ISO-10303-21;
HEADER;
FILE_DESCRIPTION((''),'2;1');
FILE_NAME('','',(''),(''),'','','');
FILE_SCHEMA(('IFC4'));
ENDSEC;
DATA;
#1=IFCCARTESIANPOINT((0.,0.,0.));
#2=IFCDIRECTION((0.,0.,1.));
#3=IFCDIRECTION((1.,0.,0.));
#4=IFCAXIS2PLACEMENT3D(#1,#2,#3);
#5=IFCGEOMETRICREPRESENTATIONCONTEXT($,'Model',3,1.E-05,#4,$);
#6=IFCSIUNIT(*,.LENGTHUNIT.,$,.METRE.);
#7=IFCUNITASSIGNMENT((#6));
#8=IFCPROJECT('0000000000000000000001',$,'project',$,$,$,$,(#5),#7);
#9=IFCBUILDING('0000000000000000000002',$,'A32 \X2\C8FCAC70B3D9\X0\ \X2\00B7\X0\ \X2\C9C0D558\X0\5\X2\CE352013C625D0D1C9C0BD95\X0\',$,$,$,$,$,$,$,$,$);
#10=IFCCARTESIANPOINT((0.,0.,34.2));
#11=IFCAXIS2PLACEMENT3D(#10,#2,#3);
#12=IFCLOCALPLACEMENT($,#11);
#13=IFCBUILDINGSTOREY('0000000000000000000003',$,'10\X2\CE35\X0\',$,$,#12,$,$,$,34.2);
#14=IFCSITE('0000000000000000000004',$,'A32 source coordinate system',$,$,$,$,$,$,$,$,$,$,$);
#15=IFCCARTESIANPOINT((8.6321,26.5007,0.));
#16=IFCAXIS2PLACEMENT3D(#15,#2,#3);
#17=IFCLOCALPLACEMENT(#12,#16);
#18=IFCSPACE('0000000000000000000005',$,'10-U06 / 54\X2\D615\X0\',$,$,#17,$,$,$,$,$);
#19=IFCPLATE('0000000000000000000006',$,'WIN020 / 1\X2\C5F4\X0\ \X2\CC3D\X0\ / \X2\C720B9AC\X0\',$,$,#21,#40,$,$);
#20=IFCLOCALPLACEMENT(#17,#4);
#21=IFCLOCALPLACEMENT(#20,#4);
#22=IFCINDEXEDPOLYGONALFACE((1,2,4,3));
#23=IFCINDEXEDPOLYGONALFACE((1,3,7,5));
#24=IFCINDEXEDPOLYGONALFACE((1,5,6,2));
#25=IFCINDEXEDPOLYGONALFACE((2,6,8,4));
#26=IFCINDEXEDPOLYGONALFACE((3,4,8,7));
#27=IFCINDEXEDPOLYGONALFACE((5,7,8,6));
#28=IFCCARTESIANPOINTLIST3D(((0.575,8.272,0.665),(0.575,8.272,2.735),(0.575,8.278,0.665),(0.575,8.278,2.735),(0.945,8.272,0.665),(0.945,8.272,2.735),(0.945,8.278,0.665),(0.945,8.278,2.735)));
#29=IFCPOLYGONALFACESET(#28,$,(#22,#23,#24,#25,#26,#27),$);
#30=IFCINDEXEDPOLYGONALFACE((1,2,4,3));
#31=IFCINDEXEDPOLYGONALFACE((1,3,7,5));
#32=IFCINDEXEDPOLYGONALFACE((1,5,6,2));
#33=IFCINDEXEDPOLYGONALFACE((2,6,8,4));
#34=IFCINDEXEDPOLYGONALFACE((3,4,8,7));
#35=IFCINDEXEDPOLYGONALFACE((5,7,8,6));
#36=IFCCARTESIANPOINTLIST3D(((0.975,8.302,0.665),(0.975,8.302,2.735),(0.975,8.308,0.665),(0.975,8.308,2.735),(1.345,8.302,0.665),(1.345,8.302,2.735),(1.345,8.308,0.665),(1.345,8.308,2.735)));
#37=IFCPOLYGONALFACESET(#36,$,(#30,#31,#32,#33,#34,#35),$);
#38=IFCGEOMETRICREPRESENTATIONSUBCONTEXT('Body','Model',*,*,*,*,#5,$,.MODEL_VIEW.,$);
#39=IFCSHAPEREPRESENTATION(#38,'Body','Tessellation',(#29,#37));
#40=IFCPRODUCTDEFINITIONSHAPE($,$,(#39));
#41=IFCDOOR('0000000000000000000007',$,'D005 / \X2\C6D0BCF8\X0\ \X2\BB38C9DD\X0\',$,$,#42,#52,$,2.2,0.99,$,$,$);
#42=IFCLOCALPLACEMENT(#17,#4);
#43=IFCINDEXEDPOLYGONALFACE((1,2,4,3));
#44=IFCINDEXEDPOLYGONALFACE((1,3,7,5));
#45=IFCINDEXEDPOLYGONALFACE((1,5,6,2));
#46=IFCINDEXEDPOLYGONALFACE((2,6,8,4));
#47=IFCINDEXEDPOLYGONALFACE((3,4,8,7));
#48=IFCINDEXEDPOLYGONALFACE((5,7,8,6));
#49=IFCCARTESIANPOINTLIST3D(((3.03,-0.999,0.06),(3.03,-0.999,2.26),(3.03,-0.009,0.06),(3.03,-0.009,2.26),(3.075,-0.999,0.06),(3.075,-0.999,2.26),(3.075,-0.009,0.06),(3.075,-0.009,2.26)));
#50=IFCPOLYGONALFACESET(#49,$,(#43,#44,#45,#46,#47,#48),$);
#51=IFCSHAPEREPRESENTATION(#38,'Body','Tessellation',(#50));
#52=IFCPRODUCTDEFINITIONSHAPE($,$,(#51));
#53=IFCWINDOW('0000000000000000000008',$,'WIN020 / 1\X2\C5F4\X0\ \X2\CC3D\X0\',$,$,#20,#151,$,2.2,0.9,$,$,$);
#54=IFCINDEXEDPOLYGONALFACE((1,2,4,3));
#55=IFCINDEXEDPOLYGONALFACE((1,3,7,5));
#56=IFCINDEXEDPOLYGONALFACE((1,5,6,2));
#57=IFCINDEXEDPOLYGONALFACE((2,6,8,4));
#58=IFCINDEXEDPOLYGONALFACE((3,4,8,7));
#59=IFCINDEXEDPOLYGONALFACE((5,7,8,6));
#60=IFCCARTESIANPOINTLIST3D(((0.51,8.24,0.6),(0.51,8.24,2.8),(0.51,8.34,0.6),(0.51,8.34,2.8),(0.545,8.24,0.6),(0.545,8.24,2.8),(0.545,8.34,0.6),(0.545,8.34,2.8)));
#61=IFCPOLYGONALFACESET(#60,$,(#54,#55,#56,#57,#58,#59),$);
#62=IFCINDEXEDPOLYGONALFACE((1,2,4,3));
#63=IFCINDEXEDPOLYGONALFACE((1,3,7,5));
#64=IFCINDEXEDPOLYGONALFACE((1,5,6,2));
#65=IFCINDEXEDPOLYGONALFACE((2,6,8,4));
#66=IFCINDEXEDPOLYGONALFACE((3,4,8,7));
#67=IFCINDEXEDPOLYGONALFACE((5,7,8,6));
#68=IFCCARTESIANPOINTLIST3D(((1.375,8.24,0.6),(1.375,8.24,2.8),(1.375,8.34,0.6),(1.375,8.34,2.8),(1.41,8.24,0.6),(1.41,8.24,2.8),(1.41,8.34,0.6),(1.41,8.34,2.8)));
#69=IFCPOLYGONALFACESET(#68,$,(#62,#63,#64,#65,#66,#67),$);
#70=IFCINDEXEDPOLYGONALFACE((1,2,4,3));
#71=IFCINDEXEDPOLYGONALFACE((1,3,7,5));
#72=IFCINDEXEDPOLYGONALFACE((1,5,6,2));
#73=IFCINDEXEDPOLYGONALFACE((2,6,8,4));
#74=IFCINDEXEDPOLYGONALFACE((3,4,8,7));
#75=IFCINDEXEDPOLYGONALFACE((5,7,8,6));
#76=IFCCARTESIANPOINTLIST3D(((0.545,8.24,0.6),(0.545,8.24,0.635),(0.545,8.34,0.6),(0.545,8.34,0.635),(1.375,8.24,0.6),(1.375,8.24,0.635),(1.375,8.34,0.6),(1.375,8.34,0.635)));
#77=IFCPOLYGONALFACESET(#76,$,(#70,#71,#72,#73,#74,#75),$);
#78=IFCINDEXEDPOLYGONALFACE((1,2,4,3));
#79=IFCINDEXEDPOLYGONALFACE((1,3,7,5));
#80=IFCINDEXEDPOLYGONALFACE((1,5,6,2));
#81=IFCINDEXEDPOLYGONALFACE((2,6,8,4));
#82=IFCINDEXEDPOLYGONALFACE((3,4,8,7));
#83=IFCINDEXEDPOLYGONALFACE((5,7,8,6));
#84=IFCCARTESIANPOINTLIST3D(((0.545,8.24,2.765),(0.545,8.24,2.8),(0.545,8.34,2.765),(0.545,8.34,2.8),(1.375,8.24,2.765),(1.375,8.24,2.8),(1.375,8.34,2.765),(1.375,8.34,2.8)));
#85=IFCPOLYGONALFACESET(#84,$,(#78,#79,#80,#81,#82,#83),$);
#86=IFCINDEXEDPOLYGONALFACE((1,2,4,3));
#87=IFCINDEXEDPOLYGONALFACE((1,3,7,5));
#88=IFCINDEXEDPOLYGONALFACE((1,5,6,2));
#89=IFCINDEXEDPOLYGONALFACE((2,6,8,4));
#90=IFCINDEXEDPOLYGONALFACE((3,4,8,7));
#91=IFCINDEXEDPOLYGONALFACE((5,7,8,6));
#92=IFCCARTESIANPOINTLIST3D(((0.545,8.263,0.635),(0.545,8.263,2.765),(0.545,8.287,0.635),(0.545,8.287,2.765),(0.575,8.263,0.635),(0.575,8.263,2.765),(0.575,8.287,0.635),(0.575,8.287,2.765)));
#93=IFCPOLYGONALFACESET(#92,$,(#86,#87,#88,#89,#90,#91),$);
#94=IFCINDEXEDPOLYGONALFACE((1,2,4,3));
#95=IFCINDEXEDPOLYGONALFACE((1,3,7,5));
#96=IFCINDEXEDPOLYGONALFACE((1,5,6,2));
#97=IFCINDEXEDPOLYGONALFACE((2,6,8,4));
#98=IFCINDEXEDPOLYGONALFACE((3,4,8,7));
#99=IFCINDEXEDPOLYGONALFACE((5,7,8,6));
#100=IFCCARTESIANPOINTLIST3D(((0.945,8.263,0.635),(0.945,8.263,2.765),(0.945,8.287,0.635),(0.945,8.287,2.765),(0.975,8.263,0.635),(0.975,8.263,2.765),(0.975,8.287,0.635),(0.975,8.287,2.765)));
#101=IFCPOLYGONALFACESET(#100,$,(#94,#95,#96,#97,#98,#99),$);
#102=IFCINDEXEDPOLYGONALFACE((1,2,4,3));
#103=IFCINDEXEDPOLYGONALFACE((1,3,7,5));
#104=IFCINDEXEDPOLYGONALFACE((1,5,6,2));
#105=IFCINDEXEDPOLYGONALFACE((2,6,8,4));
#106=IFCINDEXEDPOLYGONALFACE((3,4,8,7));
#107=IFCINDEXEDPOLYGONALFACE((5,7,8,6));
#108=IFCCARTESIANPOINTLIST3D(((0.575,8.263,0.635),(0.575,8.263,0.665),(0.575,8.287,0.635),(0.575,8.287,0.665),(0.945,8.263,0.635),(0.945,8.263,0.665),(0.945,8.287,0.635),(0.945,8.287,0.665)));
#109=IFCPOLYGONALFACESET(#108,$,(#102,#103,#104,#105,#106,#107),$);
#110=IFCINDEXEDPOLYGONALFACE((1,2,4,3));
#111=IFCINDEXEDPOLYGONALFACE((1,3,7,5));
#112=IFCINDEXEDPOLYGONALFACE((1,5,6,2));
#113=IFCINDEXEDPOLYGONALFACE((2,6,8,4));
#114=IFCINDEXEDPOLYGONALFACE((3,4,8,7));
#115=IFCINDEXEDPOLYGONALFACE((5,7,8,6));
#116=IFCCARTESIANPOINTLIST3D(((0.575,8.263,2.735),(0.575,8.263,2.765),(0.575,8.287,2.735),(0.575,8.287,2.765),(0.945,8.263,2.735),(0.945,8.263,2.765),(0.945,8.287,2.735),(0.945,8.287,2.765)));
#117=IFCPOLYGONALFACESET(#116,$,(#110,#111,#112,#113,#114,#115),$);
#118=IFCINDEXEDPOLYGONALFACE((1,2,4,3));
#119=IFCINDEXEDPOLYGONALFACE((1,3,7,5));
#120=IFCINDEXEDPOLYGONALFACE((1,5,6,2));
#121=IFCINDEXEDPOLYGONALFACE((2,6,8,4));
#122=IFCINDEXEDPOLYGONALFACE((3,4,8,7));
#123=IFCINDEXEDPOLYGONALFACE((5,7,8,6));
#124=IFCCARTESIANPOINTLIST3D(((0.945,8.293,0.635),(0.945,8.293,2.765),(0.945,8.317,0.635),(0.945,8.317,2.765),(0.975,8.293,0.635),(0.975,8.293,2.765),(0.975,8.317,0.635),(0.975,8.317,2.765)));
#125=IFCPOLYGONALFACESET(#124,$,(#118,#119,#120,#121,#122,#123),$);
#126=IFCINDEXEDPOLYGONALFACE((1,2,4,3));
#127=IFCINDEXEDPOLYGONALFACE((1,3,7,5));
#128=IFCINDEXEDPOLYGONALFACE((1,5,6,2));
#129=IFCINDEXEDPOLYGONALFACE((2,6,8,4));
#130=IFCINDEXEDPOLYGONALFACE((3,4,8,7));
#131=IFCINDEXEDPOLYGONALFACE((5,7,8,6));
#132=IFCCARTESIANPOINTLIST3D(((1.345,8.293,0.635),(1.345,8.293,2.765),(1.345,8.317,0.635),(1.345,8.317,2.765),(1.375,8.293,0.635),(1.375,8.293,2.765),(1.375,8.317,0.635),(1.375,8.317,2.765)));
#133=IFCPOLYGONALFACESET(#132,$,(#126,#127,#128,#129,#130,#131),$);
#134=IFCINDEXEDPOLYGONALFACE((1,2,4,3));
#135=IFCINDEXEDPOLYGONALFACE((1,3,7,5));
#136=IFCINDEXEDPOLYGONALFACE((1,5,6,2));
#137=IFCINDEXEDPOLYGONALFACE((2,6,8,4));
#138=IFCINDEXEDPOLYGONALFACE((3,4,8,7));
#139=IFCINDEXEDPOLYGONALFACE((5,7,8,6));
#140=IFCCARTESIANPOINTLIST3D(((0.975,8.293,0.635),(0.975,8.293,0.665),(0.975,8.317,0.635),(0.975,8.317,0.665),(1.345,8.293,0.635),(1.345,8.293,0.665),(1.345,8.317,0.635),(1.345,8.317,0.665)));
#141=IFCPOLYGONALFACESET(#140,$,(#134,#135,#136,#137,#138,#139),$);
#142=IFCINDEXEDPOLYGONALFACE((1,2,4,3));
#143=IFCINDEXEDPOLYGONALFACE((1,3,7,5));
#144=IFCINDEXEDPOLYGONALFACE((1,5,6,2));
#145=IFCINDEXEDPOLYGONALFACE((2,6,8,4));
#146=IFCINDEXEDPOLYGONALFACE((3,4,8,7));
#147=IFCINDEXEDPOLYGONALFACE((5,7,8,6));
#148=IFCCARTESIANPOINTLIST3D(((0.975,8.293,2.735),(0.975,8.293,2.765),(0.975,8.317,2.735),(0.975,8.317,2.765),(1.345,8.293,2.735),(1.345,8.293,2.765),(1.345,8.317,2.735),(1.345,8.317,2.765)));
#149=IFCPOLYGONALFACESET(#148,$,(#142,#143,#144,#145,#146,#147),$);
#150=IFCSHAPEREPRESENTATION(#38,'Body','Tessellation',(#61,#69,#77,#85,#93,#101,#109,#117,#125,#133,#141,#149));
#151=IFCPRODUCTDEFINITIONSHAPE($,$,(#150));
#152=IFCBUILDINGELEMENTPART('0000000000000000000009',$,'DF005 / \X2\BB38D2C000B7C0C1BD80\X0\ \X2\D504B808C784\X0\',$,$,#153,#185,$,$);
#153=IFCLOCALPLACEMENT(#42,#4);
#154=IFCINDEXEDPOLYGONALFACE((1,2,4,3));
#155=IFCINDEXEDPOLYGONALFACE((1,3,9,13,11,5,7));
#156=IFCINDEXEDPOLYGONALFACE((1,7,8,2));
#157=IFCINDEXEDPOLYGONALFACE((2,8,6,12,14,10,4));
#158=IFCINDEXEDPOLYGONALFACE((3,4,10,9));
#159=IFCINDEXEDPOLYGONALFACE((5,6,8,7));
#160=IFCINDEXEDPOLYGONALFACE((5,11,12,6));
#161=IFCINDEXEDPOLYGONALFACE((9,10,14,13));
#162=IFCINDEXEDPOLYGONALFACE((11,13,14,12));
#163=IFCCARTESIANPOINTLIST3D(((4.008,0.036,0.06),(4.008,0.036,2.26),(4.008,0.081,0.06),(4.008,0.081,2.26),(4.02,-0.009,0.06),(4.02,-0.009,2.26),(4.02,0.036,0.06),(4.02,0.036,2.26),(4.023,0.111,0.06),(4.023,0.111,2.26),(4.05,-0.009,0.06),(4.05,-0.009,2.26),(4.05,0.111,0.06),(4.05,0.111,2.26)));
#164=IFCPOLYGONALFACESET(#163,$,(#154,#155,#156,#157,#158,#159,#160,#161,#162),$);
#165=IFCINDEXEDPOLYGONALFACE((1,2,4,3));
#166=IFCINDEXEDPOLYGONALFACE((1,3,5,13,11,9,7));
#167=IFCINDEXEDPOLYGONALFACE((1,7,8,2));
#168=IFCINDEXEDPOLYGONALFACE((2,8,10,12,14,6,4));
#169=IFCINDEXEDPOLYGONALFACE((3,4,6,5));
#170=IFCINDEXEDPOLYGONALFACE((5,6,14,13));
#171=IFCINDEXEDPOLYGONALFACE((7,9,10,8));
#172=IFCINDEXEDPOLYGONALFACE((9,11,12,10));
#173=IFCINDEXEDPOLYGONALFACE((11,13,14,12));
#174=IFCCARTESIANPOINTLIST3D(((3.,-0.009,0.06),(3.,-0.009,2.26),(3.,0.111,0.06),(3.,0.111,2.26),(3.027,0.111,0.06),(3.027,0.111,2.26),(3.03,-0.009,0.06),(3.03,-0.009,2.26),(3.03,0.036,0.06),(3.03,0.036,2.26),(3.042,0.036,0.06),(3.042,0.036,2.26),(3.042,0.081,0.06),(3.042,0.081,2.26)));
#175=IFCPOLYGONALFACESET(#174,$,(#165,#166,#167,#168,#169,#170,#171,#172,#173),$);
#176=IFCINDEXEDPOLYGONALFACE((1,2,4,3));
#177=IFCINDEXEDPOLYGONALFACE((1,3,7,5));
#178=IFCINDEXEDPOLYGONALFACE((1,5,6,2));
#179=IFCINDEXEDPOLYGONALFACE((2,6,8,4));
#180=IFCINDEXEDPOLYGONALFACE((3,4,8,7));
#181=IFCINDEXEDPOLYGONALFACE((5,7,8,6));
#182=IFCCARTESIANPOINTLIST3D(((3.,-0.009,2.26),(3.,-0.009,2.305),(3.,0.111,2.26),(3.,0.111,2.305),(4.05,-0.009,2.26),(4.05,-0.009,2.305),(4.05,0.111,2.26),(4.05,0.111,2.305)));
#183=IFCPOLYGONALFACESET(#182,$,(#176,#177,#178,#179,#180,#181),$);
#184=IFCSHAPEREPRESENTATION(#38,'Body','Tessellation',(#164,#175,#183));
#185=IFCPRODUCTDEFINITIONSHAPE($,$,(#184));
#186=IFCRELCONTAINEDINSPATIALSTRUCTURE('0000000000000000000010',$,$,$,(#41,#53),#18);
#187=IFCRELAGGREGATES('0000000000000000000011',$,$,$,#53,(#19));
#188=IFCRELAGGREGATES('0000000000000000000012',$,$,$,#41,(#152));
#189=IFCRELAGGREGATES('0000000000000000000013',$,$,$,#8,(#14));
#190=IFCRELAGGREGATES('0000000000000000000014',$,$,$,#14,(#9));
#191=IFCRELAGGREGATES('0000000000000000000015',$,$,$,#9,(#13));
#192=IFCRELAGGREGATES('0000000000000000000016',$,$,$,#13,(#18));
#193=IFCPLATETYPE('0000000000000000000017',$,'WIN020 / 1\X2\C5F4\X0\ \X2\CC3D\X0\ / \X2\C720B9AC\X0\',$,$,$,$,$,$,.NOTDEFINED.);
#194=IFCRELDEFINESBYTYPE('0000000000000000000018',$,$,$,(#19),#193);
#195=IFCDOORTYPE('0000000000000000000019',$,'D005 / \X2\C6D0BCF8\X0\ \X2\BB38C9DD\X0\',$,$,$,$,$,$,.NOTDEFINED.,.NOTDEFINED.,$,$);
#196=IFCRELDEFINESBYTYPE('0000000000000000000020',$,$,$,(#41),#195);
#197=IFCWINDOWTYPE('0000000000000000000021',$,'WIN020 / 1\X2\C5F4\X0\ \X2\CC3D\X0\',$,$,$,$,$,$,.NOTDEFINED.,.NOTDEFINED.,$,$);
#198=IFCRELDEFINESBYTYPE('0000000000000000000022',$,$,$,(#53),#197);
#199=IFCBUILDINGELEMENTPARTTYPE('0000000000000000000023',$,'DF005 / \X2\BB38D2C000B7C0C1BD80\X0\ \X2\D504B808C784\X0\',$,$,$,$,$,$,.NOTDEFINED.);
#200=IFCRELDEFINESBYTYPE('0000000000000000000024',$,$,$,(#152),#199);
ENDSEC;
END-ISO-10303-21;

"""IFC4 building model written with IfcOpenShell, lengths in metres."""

from ifc_helpers import new_model, si_unit, frame, origin, origin_with_axes, place, context, subcontext, project, spatial, polyline, outline, extrude, source, transform, mapped, type_object, type_shapes, element, aggregate, save


model = new_model("IFC4")

# Units and contexts
model_context = context("Model", 3, precision=1e-05, world=origin_with_axes())
body_context = subcontext(model_context, "Body", "Model", "MODEL_VIEW")
ifc_project = project(units=[si_unit("LENGTHUNIT", "METRE")], contexts=[model_context])

# Plate
storey_placement = place(None, frame((0.0, 0.0, 34.2), z_axis=(0.0, 0.0, 1.0), x_axis=(1.0, 0.0, 0.0)))
space_1_placement = place(storey_placement, frame((8.6321, 26.5007, 0.0), z_axis=(0.0, 0.0, 1.0), x_axis=(1.0, 0.0, 0.0)))
plate_type_1 = type_object("IfcPlateType", Name="WIN020 / 1열 창 / 유리", PredefinedType="NOTDEFINED")
shared_shape_1 = source(origin(), body_context, "Body", "SweptSolid", [
    extrude(outline(polyline([(0.575, 8.272), (0.575, 8.278), (0.945, 8.278), (0.945, 8.272), (0.575, 8.272)])), frame((0.0, 0.0, 0.665)), (0.0, 0.0, 1.0), 2.07),
    extrude(outline(polyline([(0.975, 8.302), (0.975, 8.308), (1.345, 8.308), (1.345, 8.302), (0.975, 8.302)])), frame((0.0, 0.0, 0.665)), (0.0, 0.0, 1.0), 2.07),
])
type_shapes(plate_type_1, [shared_shape_1])
window_1_placement = place(space_1_placement, origin_with_axes())
plate_1_placement = place(window_1_placement, origin_with_axes())
plate_1 = element("IfcPlate", 1, at=plate_1_placement, type_object=plate_type_1, Name="WIN020 / 1열 창 / 유리", context=body_context, shape_type="MappedRepresentation", body=[
    mapped(shared_shape_1, transform((0.0, 0.0, 0.0), scale=1.0)),
])

# Site, building, storey, space
site = spatial("IfcSite", under=ifc_project, Name="A32 source coordinate system")
building = spatial("IfcBuilding", under=site, Name="A32 주거동 · 지하5층–옥탑지붕")
storey = spatial("IfcBuildingStorey", under=building, at=storey_placement, Name="10층", Elevation=34.2)
space_1 = spatial("IfcSpace", under=storey, at=space_1_placement, Name="10-U06 / 54형")

# Door
door_type_1 = type_object("IfcDoorType", Name="D005 / 원본 문짝", OperationType="NOTDEFINED", PredefinedType="NOTDEFINED")
shared_shape_2 = source(origin(), body_context, "Body", "SweptSolid", [
    extrude(outline(polyline([(3.075, -0.999), (3.03, -0.999), (3.03, -0.009), (3.075, -0.009), (3.075, -0.999)])), frame((0.0, 0.0, 0.06)), (0.0, 0.0, 1.0), 2.2),
])
type_shapes(door_type_1, [shared_shape_2])
door_1_placement = place(space_1_placement, origin_with_axes())
door_1 = element("IfcDoor", 2, at=door_1_placement, inside=space_1, type_object=door_type_1, Name="D005 / 원본 문짝", OverallHeight=2.2, OverallWidth=0.99, context=body_context, shape_type="MappedRepresentation", body=[
    mapped(shared_shape_2, transform((0.0, 0.0, 0.0), scale=1.0)),
])

# Window
window_type_1 = type_object("IfcWindowType", Name="WIN020 / 1열 창", PartitioningType="NOTDEFINED", PredefinedType="NOTDEFINED")
shared_shape_3 = source(origin(), body_context, "Body", "SweptSolid", [
    extrude(outline(polyline([(0.51, 8.24), (0.51, 8.34), (0.545, 8.34), (0.545, 8.24), (0.51, 8.24)])), frame((0.0, 0.0, 0.6)), (0.0, 0.0, 1.0), 2.2),
    extrude(outline(polyline([(1.375, 8.24), (1.375, 8.34), (1.41, 8.34), (1.41, 8.24), (1.375, 8.24)])), frame((0.0, 0.0, 0.6)), (0.0, 0.0, 1.0), 2.2),
    extrude(outline(polyline([(0.545, 8.24), (0.545, 8.34), (1.375, 8.34), (1.375, 8.24), (0.545, 8.24)])), frame((0.0, 0.0, 0.6)), (0.0, 0.0, 1.0), 0.035),
    extrude(outline(polyline([(0.545, 8.24), (0.545, 8.34), (1.375, 8.34), (1.375, 8.24), (0.545, 8.24)])), frame((0.0, 0.0, 2.765)), (0.0, 0.0, 1.0), 0.035),
    extrude(outline(polyline([(0.545, 8.263), (0.545, 8.287), (0.575, 8.287), (0.575, 8.263), (0.545, 8.263)])), frame((0.0, 0.0, 0.635)), (0.0, 0.0, 1.0), 2.13),
    extrude(outline(polyline([(0.945, 8.263), (0.945, 8.287), (0.975, 8.287), (0.975, 8.263), (0.945, 8.263)])), frame((0.0, 0.0, 0.635)), (0.0, 0.0, 1.0), 2.13),
    extrude(outline(polyline([(0.575, 8.263), (0.575, 8.287), (0.945, 8.287), (0.945, 8.263), (0.575, 8.263)])), frame((0.0, 0.0, 0.635)), (0.0, 0.0, 1.0), 0.03),
    extrude(outline(polyline([(0.575, 8.263), (0.575, 8.287), (0.945, 8.287), (0.945, 8.263), (0.575, 8.263)])), frame((0.0, 0.0, 2.735)), (0.0, 0.0, 1.0), 0.03),
    extrude(outline(polyline([(0.945, 8.293), (0.945, 8.317), (0.975, 8.317), (0.975, 8.293), (0.945, 8.293)])), frame((0.0, 0.0, 0.635)), (0.0, 0.0, 1.0), 2.13),
    extrude(outline(polyline([(1.345, 8.293), (1.345, 8.317), (1.375, 8.317), (1.375, 8.293), (1.345, 8.293)])), frame((0.0, 0.0, 0.635)), (0.0, 0.0, 1.0), 2.13),
    extrude(outline(polyline([(0.975, 8.293), (0.975, 8.317), (1.345, 8.317), (1.345, 8.293), (0.975, 8.293)])), frame((0.0, 0.0, 0.635)), (0.0, 0.0, 1.0), 0.03),
    extrude(outline(polyline([(0.975, 8.293), (0.975, 8.317), (1.345, 8.317), (1.345, 8.293), (0.975, 8.293)])), frame((0.0, 0.0, 2.735)), (0.0, 0.0, 1.0), 0.03),
])
type_shapes(window_type_1, [shared_shape_3])
window_1 = element("IfcWindow", 3, at=window_1_placement, inside=space_1, type_object=window_type_1, Name="WIN020 / 1열 창", OverallHeight=2.2, OverallWidth=0.9, context=body_context, shape_type="MappedRepresentation", body=[
    mapped(shared_shape_3, transform((0.0, 0.0, 0.0), scale=1.0)),
])
aggregate(window_1, [plate_1])

# Building element part
building_element_part_type_1 = type_object("IfcBuildingElementPartType", Name="DF005 / 문틀·상부 프레임", PredefinedType="NOTDEFINED")
shared_shape_4 = source(origin(), body_context, "Body", "SweptSolid", [
    extrude(outline(polyline([(4.02, -0.009), (4.02, 0.036), (4.008, 0.036), (4.008, 0.081), (4.023, 0.111), (4.05, 0.111), (4.05, -0.009), (4.02, -0.009)])), frame((0.0, 0.0, 0.06)), (0.0, 0.0, 1.0), 2.2),
    extrude(outline(polyline([(3.0, 0.111), (3.027, 0.111), (3.042, 0.081), (3.042, 0.036), (3.03, 0.036), (3.03, -0.009), (3.0, -0.009), (3.0, 0.111)])), frame((0.0, 0.0, 0.06)), (0.0, 0.0, 1.0), 2.2),
    extrude(outline(polyline([(3.0, -0.009), (3.0, 0.111), (4.05, 0.111), (4.05, -0.009), (3.0, -0.009)])), frame((0.0, 0.0, 2.26)), (0.0, 0.0, 1.0), 0.045),
])
type_shapes(building_element_part_type_1, [shared_shape_4])
building_element_part_1_placement = place(door_1_placement, origin_with_axes())
building_element_part_1 = element("IfcBuildingElementPart", 4, at=building_element_part_1_placement, type_object=building_element_part_type_1, Name="DF005 / 문틀·상부 프레임", context=body_context, shape_type="MappedRepresentation", body=[
    mapped(shared_shape_4, transform((0.0, 0.0, 0.0), scale=1.0)),
])
aggregate(door_1, [building_element_part_1])

save(model, "model.ifc")
